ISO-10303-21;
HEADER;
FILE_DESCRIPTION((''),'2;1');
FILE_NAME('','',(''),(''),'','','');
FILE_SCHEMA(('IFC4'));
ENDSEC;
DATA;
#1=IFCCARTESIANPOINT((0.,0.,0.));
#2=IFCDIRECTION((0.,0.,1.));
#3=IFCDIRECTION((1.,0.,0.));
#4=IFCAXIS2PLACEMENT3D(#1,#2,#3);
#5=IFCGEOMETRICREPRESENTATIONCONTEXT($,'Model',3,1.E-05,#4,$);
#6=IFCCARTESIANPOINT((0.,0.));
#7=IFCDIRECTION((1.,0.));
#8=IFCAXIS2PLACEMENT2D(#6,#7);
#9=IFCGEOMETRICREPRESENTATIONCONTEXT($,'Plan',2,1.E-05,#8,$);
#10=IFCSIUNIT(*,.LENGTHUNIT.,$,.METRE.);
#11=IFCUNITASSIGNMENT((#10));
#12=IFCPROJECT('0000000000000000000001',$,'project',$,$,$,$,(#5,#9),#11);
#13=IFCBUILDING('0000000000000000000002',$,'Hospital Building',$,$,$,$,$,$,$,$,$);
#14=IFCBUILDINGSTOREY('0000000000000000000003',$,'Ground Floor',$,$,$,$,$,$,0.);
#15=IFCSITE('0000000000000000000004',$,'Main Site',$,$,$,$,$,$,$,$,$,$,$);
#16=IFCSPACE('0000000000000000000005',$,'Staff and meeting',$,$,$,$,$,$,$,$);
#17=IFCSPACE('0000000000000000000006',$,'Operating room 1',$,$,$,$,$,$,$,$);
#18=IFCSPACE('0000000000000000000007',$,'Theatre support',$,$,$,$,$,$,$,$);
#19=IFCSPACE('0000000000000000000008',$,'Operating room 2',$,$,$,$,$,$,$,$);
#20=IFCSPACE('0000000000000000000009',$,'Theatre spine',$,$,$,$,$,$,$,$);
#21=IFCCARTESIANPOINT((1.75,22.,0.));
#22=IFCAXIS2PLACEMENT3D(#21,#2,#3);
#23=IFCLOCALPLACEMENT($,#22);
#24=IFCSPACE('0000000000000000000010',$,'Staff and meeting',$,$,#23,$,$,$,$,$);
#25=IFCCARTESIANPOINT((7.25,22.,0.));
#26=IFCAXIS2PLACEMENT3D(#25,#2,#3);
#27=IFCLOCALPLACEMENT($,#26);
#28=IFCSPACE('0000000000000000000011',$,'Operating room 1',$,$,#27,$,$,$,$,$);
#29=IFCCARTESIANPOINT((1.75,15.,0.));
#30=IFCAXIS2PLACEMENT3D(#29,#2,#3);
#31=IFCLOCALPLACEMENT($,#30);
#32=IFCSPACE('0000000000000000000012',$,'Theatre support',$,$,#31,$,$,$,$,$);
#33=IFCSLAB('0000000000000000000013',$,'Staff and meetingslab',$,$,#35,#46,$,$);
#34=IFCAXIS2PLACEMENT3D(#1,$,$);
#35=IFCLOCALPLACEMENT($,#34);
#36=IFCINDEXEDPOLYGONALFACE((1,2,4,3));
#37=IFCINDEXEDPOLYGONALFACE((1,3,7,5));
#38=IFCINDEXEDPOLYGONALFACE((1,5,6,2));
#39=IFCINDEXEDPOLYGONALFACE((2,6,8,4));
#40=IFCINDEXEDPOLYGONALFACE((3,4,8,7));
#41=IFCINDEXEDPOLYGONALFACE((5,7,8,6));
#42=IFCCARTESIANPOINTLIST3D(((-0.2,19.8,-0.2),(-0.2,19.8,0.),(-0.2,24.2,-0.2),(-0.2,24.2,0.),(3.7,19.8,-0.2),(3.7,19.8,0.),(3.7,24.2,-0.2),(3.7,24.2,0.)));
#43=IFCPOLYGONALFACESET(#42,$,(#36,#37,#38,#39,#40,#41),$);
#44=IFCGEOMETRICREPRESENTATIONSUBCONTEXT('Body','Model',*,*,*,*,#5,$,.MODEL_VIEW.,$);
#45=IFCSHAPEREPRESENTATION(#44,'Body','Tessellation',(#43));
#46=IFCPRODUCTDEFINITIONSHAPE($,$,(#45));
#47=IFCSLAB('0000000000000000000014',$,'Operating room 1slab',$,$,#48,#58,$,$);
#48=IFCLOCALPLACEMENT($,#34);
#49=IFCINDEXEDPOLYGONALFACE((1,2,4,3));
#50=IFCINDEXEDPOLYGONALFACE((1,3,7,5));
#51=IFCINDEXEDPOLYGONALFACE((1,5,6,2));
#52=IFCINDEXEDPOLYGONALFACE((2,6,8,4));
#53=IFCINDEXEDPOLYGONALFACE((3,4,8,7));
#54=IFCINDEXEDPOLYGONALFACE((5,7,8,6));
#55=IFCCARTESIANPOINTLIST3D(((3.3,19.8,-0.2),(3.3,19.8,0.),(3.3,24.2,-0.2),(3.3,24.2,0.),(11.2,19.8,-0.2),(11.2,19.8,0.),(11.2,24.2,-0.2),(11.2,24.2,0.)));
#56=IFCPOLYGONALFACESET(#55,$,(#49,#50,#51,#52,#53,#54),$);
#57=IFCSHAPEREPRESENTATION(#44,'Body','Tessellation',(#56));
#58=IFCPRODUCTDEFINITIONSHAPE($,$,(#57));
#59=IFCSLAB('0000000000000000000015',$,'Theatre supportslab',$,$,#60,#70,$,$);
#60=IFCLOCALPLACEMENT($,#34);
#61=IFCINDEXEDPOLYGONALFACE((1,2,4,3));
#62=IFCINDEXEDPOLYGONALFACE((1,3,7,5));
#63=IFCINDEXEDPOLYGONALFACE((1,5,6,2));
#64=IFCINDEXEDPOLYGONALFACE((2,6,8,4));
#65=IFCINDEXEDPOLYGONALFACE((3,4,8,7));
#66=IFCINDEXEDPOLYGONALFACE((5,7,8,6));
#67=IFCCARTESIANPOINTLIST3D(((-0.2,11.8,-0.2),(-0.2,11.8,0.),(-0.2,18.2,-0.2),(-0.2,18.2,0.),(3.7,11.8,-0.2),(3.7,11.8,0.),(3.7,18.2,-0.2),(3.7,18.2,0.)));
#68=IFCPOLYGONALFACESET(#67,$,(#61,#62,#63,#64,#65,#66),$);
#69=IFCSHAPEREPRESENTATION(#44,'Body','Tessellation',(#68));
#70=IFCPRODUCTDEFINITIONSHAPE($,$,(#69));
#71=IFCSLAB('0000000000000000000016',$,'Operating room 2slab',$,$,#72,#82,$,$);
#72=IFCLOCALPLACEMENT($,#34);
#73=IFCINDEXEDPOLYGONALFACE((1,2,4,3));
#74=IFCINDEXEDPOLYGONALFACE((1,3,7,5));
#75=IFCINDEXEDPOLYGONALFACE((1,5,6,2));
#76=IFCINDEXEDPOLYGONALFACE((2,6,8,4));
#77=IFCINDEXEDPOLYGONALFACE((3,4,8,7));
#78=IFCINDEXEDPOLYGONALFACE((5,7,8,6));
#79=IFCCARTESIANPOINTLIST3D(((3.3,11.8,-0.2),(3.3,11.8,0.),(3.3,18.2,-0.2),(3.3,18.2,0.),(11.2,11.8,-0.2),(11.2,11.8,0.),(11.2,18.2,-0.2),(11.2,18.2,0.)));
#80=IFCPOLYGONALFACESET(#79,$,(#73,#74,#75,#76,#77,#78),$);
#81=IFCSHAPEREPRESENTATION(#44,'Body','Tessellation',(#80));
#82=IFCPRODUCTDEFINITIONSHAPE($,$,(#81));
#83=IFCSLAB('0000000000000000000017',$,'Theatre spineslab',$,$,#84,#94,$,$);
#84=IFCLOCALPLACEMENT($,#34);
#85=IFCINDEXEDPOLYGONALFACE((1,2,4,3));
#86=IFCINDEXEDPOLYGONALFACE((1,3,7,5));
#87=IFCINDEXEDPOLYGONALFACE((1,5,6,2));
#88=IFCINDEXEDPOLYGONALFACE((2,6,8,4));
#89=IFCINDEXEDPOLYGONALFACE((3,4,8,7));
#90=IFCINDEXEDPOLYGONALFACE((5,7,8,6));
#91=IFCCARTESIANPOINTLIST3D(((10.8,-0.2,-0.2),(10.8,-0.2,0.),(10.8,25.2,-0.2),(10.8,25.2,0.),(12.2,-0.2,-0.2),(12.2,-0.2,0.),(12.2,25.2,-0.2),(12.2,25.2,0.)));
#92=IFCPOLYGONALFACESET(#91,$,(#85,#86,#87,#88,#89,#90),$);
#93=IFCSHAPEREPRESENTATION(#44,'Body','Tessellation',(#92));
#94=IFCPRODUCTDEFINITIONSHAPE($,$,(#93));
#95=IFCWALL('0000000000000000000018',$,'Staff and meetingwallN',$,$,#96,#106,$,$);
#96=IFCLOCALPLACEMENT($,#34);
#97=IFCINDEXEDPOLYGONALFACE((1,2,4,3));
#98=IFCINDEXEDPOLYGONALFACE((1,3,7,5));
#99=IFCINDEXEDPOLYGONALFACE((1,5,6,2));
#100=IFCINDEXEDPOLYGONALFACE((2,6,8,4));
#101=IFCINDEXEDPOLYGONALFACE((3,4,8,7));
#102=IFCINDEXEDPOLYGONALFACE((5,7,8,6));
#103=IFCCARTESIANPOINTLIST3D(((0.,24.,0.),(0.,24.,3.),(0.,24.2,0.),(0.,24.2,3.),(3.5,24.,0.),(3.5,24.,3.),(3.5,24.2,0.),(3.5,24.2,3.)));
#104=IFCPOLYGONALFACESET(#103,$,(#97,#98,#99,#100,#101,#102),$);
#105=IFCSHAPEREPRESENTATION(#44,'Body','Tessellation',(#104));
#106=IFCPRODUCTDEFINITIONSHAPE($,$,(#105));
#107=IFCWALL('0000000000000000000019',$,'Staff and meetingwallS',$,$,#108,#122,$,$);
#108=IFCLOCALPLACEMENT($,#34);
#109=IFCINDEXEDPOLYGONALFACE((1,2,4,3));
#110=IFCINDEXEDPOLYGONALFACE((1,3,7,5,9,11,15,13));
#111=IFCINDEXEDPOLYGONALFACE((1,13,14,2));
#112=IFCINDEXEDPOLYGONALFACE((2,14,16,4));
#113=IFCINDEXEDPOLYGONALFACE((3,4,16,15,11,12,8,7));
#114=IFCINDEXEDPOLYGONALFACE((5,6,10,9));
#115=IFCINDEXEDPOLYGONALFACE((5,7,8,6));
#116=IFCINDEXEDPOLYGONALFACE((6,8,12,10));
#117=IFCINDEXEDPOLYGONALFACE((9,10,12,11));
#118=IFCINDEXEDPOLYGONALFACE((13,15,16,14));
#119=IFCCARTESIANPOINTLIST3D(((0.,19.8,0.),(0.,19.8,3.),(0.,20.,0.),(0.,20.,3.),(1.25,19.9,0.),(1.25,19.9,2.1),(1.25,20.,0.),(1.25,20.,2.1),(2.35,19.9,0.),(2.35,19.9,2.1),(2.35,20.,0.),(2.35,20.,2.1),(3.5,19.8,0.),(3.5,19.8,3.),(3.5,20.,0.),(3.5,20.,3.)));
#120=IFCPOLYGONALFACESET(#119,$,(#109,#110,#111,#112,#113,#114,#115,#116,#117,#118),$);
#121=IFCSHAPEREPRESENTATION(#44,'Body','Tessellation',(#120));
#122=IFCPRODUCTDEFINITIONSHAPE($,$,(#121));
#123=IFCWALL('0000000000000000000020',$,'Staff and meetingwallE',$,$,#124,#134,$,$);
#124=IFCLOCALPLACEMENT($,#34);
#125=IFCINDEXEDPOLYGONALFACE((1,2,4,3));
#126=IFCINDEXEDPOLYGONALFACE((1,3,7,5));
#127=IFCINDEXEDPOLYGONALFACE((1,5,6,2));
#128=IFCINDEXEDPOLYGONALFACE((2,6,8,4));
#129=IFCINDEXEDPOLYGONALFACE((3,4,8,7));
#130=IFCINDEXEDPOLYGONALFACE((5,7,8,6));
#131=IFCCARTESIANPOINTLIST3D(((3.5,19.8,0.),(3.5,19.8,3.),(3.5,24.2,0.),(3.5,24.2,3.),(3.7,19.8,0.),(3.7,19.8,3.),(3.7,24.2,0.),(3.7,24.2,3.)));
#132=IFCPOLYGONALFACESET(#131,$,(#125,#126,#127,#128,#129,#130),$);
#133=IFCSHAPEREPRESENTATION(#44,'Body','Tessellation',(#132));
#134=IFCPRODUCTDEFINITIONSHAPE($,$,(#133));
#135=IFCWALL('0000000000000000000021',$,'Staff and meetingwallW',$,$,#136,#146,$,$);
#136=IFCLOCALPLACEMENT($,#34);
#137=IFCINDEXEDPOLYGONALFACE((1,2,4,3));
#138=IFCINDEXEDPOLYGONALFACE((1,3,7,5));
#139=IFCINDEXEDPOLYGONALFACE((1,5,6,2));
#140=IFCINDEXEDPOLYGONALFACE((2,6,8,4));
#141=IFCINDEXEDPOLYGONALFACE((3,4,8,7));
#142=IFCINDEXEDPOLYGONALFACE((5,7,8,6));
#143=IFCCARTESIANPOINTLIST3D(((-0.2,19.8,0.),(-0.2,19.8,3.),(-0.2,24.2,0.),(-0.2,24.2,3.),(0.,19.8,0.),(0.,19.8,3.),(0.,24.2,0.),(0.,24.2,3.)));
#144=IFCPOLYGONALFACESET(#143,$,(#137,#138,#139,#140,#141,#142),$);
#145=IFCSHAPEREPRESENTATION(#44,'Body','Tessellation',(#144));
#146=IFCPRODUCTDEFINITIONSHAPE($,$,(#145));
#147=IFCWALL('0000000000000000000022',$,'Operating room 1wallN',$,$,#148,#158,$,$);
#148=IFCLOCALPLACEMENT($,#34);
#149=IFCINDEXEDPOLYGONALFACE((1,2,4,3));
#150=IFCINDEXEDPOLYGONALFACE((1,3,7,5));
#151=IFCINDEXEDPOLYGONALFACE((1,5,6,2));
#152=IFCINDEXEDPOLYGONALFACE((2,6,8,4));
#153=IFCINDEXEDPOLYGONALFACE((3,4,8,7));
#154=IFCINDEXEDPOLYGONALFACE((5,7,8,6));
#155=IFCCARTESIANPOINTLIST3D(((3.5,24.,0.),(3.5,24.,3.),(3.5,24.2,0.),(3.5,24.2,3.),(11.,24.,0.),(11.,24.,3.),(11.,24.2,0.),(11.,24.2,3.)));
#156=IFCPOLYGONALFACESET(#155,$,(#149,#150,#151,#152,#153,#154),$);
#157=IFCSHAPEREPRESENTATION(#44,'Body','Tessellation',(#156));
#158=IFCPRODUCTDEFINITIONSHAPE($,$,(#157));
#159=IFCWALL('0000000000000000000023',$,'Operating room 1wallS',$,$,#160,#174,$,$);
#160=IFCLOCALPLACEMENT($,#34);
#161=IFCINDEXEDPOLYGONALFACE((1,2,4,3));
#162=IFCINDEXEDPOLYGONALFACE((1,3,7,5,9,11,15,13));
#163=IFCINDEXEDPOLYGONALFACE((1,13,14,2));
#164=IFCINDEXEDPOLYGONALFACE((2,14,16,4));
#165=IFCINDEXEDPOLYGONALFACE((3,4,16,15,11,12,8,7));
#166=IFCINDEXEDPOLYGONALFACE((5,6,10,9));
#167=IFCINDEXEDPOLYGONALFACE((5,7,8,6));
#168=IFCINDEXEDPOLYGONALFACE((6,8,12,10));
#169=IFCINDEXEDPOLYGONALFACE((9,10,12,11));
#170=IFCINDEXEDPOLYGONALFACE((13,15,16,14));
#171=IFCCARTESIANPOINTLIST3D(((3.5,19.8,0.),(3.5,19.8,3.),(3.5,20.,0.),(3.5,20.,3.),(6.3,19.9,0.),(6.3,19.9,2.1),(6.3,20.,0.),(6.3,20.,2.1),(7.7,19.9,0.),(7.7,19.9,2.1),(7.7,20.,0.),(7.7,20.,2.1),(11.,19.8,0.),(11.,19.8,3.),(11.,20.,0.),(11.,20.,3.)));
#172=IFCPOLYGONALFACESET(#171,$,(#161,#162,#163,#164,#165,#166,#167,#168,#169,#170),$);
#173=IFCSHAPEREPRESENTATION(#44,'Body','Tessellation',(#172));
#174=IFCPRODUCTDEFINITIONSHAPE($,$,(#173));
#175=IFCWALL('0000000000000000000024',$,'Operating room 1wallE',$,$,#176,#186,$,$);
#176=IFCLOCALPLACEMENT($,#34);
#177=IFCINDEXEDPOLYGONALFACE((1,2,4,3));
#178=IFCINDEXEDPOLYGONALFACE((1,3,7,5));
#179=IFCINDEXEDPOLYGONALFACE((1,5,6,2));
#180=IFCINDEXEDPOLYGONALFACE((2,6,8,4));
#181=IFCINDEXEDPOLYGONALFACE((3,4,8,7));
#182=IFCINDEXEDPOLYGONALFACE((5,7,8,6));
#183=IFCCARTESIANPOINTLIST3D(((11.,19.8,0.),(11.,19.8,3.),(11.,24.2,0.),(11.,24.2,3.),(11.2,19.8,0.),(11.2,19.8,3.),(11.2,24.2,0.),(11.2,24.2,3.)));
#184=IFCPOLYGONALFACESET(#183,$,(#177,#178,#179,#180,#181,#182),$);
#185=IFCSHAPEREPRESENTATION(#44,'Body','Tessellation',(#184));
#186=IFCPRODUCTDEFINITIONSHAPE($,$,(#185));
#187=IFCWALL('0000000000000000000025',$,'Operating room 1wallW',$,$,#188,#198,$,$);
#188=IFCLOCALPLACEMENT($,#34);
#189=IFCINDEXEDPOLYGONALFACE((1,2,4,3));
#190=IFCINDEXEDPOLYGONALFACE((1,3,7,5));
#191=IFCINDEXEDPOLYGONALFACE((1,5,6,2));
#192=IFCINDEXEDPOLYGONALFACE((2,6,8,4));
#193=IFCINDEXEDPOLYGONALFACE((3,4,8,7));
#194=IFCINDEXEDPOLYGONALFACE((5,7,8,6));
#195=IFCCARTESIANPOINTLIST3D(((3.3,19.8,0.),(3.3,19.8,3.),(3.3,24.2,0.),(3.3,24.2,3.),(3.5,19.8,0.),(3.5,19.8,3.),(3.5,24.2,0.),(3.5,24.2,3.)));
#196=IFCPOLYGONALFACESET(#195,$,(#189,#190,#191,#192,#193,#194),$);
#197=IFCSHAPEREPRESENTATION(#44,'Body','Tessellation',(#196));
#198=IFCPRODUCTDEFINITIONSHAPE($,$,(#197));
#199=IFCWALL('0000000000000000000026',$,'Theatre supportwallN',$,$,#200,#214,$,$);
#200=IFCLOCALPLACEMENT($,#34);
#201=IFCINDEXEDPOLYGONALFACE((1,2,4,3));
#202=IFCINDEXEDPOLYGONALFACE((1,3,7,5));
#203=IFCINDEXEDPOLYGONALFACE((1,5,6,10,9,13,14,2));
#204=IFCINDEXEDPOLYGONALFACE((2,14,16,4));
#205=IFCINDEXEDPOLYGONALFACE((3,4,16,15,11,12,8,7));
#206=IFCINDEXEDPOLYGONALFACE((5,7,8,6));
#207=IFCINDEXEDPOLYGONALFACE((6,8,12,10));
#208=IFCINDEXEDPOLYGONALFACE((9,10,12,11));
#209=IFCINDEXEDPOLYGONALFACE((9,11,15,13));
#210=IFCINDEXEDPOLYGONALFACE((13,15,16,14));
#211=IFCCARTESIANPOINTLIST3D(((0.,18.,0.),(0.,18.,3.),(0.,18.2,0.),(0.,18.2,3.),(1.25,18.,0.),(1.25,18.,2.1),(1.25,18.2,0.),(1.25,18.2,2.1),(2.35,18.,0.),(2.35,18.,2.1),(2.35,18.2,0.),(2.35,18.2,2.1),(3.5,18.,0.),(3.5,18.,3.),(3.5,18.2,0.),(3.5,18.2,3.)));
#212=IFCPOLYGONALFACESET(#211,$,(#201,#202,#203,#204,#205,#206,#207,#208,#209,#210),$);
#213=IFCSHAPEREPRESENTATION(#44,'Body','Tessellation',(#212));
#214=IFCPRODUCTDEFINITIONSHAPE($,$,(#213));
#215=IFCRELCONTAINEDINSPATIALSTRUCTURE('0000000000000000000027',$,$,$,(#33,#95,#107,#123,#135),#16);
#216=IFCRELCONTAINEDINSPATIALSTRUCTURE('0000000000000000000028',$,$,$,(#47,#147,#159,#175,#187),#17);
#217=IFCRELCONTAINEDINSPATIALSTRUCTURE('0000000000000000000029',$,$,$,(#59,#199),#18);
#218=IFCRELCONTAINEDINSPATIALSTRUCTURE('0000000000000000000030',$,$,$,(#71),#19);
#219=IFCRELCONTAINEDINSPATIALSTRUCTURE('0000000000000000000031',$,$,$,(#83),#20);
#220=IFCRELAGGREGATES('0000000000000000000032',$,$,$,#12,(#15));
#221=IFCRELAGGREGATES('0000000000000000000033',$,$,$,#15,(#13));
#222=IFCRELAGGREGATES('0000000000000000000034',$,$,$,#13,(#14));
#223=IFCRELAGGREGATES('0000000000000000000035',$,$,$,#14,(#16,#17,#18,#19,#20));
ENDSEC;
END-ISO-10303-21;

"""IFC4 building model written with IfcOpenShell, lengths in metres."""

from ifc_helpers import new_model, si_unit, frame, origin_with_axes, origin_2d_with_axis, place, context, subcontext, project, spatial, indexed_curve, rectangle, outline, extrude, element, save


model = new_model("IFC4")

# Units and contexts
model_context = context("Model", 3, precision=1e-05, world=origin_with_axes())
plan_context = context("Plan", 2, precision=1e-05, world=origin_2d_with_axis())
body_context = subcontext(model_context, "Body", "Model", "MODEL_VIEW")
ifc_project = project(units=[si_unit("LENGTHUNIT", "METRE")], contexts=[model_context, plan_context])

# Site, building, storey, space
site = spatial("IfcSite", under=ifc_project, Name="Main Site")
building = spatial("IfcBuilding", under=site, Name="Hospital Building")
storey = spatial("IfcBuildingStorey", under=building, Name="Ground Floor", Elevation=0.0)
space_1 = spatial("IfcSpace", under=storey, Name="Staff and meeting")

# Slab
slab_1_placement = place(None, frame((1.75, 22.0, -0.2), z_axis=(0.0, 0.0, 1.0), x_axis=(1.0, 0.0, 0.0)))
element("IfcSlab", 1, at=slab_1_placement, inside=space_1, Name="Staff and meetingslab", context=body_context, shape_type="SweptSolid", body=[
    extrude(rectangle(XDim=3.9, YDim=4.4), origin_with_axes(), (0.0, 0.0, 1.0), 0.2),
])

# Shared definitions
space_2 = spatial("IfcSpace", under=storey, Name="Operating room 1")

# Slab
slab_2_placement = place(None, frame((7.25, 22.0, -0.2), z_axis=(0.0, 0.0, 1.0), x_axis=(1.0, 0.0, 0.0)))
element("IfcSlab", 2, at=slab_2_placement, inside=space_2, Name="Operating room 1slab", context=body_context, shape_type="SweptSolid", body=[
    extrude(rectangle(XDim=7.9, YDim=4.4), origin_with_axes(), (0.0, 0.0, 1.0), 0.2),
])

# Shared definitions
space_3 = spatial("IfcSpace", under=storey, Name="Theatre support")

# Slab
slab_3_placement = place(None, frame((1.75, 15.0, -0.2), z_axis=(0.0, 0.0, 1.0), x_axis=(1.0, 0.0, 0.0)))
element("IfcSlab", 3, at=slab_3_placement, inside=space_3, Name="Theatre supportslab", context=body_context, shape_type="SweptSolid", body=[
    extrude(rectangle(XDim=3.9, YDim=6.4), origin_with_axes(), (0.0, 0.0, 1.0), 0.2),
])

# Shared definitions
space_4 = spatial("IfcSpace", under=storey, Name="Operating room 2")

# Slab
slab_4_placement = place(None, frame((7.25, 15.0, -0.2), z_axis=(0.0, 0.0, 1.0), x_axis=(1.0, 0.0, 0.0)))
element("IfcSlab", 4, at=slab_4_placement, inside=space_4, Name="Operating room 2slab", context=body_context, shape_type="SweptSolid", body=[
    extrude(rectangle(XDim=7.9, YDim=6.4), origin_with_axes(), (0.0, 0.0, 1.0), 0.2),
])

# Shared definitions
space_5 = spatial("IfcSpace", under=storey, Name="Theatre spine")

# Slab
slab_5_placement = place(None, frame((11.5, 12.5, -0.2), z_axis=(0.0, 0.0, 1.0), x_axis=(1.0, 0.0, 0.0)))
element("IfcSlab", 5, at=slab_5_placement, inside=space_5, Name="Theatre spineslab", context=body_context, shape_type="SweptSolid", body=[
    extrude(rectangle(XDim=1.4, YDim=25.4), origin_with_axes(), (0.0, 0.0, 1.0), 0.2),
])

# Walls
wall_1_placement = place(None, frame((0.0, 24.0, 0.0), z_axis=(0.0, 0.0, 1.0), x_axis=(1.0, 0.0, 0.0)))
element("IfcWall", 6, at=wall_1_placement, inside=space_1, Name="Staff and meetingwallN", context=body_context, shape_type="SweptSolid", body=[
    extrude(outline(indexed_curve([(0.0, 0.0), (0.0, 0.2), (3.5, 0.2), (3.5, 0.0), (0.0, 0.0)], self_intersect=False)), origin_with_axes(), (0.0, 0.0, 1.0), 3.0),
])
wall_2_placement = place(None, frame((0.0, 19.8, 0.0), z_axis=(0.0, 0.0, 1.0), x_axis=(1.0, 0.0, 0.0)))
wall_2 = element("IfcWall", 7, at=wall_2_placement, inside=space_1, Name="Staff and meetingwallS", context=body_context, shape_type="SweptSolid", body=[
    extrude(outline(indexed_curve([(0.0, 0.0), (0.0, 0.2), (3.5, 0.2), (3.5, 0.0), (0.0, 0.0)], self_intersect=False)), origin_with_axes(), (0.0, 0.0, 1.0), 3.0),
])

# Shared definitions
space_6_placement = place(None, frame((1.75, 22.0, 0.0), z_axis=(0.0, 0.0, 1.0), x_axis=(1.0, 0.0, 0.0)))
space_6 = spatial("IfcSpace", at=space_6_placement, Name="Staff and meeting")

# Opening
opening_1_placement = place(wall_2_placement, frame((1.25, 0.1, 0.0), z_axis=(0.0, 0.0, 1.0), x_axis=(1.0, 0.0, 0.0)))
element("IfcOpeningElement", 8, at=opening_1_placement, inside=space_6, cuts=wall_2, context=body_context, shape_type="SweptSolid", body=[
    extrude(outline(indexed_curve([(0.0, 0.0), (0.0, 0.4), (1.1, 0.4), (1.1, 0.0), (0.0, 0.0)], self_intersect=False)), origin_with_axes(), (0.0, 0.0, 1.0), 2.1),
])

# Walls
for number, where, z_axis, x_axis, name in (
    (9, (3.7, 19.8, 0.0), (0.0, 0.0, 1.0), (0.0, 1.0, 0.0), "Staff and meetingwallE"),
    (10, (0.0, 19.8, 0.0), (0.0, 0.0, 1.0), (0.0, 1.0, 0.0), "Staff and meetingwallW"),
):
    element("IfcWall", number, at=place(None, frame(where, z_axis=z_axis, x_axis=x_axis)), inside=space_1, Name=name, context=body_context, shape_type="SweptSolid", body=[
        extrude(outline(indexed_curve([(0.0, 0.0), (0.0, 0.2), (4.4, 0.2), (4.4, 0.0), (0.0, 0.0)], self_intersect=False)), origin_with_axes(), (0.0, 0.0, 1.0), 3.0),
    ])
wall_3_placement = place(None, frame((3.5, 24.0, 0.0), z_axis=(0.0, 0.0, 1.0), x_axis=(1.0, 0.0, 0.0)))
element("IfcWall", 11, at=wall_3_placement, inside=space_2, Name="Operating room 1wallN", context=body_context, shape_type="SweptSolid", body=[
    extrude(outline(indexed_curve([(0.0, 0.0), (0.0, 0.2), (7.5, 0.2), (7.5, 0.0), (0.0, 0.0)], self_intersect=False)), origin_with_axes(), (0.0, 0.0, 1.0), 3.0),
])

# Wall
wall_4_placement = place(None, frame((3.5, 19.8, 0.0), z_axis=(0.0, 0.0, 1.0), x_axis=(1.0, 0.0, 0.0)))
wall_4 = element("IfcWall", 12, at=wall_4_placement, inside=space_2, Name="Operating room 1wallS", context=body_context, shape_type="SweptSolid", body=[
    extrude(outline(indexed_curve([(0.0, 0.0), (0.0, 0.2), (7.5, 0.2), (7.5, 0.0), (0.0, 0.0)], self_intersect=False)), origin_with_axes(), (0.0, 0.0, 1.0), 3.0),
])

# Shared definitions
space_7_placement = place(None, frame((7.25, 22.0, 0.0), z_axis=(0.0, 0.0, 1.0), x_axis=(1.0, 0.0, 0.0)))
space_7 = spatial("IfcSpace", at=space_7_placement, Name="Operating room 1")

# Opening
opening_2_placement = place(wall_4_placement, frame((2.8, 0.1, 0.0), z_axis=(0.0, 0.0, 1.0), x_axis=(1.0, 0.0, 0.0)))
element("IfcOpeningElement", 13, at=opening_2_placement, inside=space_7, cuts=wall_4, context=body_context, shape_type="SweptSolid", body=[
    extrude(outline(indexed_curve([(0.0, 0.0), (0.0, 0.4), (1.4, 0.4), (1.4, 0.0), (0.0, 0.0)], self_intersect=False)), origin_with_axes(), (0.0, 0.0, 1.0), 2.1),
])

# Walls
for number, where, z_axis, x_axis, name in (
    (14, (11.2, 19.8, 0.0), (0.0, 0.0, 1.0), (0.0, 1.0, 0.0), "Operating room 1wallE"),
    (15, (3.5, 19.8, 0.0), (0.0, 0.0, 1.0), (0.0, 1.0, 0.0), "Operating room 1wallW"),
):
    element("IfcWall", number, at=place(None, frame(where, z_axis=z_axis, x_axis=x_axis)), inside=space_2, Name=name, context=body_context, shape_type="SweptSolid", body=[
        extrude(outline(indexed_curve([(0.0, 0.0), (0.0, 0.2), (4.4, 0.2), (4.4, 0.0), (0.0, 0.0)], self_intersect=False)), origin_with_axes(), (0.0, 0.0, 1.0), 3.0),
    ])

# Wall
wall_5_placement = place(None, frame((0.0, 18.0, 0.0), z_axis=(0.0, 0.0, 1.0), x_axis=(1.0, 0.0, 0.0)))
wall_5 = element("IfcWall", 16, at=wall_5_placement, inside=space_3, Name="Theatre supportwallN", context=body_context, shape_type="SweptSolid", body=[
    extrude(outline(indexed_curve([(0.0, 0.0), (0.0, 0.2), (3.5, 0.2), (3.5, 0.0), (0.0, 0.0)], self_intersect=False)), origin_with_axes(), (0.0, 0.0, 1.0), 3.0),
])

# Shared definitions
space_8_placement = place(None, frame((1.75, 15.0, 0.0), z_axis=(0.0, 0.0, 1.0), x_axis=(1.0, 0.0, 0.0)))
space_8 = spatial("IfcSpace", at=space_8_placement, Name="Theatre support")

# Opening
opening_3_placement = place(wall_5_placement, frame((1.25, -0.1, 0.0), z_axis=(0.0, 0.0, 1.0), x_axis=(1.0, 0.0, 0.0)))
element("IfcOpeningElement", 17, at=opening_3_placement, inside=space_8, cuts=wall_5, context=body_context, shape_type="SweptSolid", body=[
    extrude(outline(indexed_curve([(0.0, 0.0), (0.0, 0.4), (1.1, 0.4), (1.1, 0.0), (0.0, 0.0)], self_intersect=False)), origin_with_axes(), (0.0, 0.0, 1.0), 2.1),
])

save(model, "model.ifc")
